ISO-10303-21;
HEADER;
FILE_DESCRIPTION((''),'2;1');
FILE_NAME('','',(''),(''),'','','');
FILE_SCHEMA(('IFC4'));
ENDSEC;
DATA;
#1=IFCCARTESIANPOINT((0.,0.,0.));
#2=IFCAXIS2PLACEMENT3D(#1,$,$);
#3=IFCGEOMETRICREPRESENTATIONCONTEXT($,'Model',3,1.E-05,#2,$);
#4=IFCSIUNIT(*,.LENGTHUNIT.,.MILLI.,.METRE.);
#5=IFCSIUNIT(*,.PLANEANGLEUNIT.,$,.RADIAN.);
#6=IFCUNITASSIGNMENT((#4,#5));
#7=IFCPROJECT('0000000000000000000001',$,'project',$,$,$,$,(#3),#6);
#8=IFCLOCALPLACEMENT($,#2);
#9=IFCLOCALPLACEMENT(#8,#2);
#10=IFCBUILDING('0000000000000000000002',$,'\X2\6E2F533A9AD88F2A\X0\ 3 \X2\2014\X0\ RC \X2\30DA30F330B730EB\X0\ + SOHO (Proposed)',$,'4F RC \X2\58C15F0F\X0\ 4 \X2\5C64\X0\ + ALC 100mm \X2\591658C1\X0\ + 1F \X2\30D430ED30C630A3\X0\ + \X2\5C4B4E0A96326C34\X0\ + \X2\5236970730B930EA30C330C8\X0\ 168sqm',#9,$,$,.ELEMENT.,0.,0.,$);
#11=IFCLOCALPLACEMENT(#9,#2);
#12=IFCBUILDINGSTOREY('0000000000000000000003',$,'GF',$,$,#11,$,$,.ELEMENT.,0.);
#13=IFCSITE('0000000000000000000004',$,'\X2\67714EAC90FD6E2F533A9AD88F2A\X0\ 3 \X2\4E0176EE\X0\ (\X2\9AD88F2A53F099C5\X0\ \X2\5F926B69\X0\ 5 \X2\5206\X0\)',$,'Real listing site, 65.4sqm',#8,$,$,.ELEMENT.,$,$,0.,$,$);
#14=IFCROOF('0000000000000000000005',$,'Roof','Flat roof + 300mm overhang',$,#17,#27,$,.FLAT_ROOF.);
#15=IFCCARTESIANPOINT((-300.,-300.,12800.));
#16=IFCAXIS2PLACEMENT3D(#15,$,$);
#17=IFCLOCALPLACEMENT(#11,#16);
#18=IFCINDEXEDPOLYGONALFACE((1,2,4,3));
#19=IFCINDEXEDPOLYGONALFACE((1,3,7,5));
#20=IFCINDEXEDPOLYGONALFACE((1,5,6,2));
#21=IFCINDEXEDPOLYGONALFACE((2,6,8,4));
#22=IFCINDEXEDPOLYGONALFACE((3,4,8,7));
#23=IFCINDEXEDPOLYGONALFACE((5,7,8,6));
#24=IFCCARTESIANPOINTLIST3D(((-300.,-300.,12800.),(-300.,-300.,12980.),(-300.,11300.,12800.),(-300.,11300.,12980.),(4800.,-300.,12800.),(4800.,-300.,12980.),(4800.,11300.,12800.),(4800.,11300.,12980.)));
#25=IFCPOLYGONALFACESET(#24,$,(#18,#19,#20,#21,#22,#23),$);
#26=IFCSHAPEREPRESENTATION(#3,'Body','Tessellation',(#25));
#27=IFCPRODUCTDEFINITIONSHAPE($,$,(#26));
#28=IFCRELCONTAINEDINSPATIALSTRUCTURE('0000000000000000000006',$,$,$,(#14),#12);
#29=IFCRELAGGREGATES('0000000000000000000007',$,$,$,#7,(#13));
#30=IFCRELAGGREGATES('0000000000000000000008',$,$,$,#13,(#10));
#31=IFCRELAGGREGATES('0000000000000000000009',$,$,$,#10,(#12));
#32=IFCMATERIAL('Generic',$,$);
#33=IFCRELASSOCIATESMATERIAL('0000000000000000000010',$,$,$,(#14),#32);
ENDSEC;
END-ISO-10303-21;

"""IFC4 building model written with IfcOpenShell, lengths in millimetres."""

from ifc_helpers import new_model, si_unit, frame, frame_2d, origin, place, context, project, spatial, rectangle, extrude, material, element, save


model = new_model("IFC4")

# Units and contexts
model_context = context("Model", 3, precision=1e-05, world=origin())
ifc_project = project(units=[si_unit("LENGTHUNIT", "METRE", prefix="MILLI"), si_unit("PLANEANGLEUNIT", "RADIAN")], contexts=[model_context])

# Site, building, storey
site_placement = place(None, origin())
site = spatial("IfcSite", under=ifc_project, at=site_placement, Name="東京都港区高輪 3 丁目 (高輪台駅 徒歩 5 分)", ObjectType="Real listing site, 65.4sqm", CompositionType="ELEMENT", RefElevation=0.0)
building_placement = place(site_placement, origin())
building = spatial("IfcBuilding", under=site, at=building_placement, Name="港区高輪 3 — RC ペンシル + SOHO (Proposed)", ObjectType="4F RC 壁式 4 層 + ALC 100mm 外壁 + 1F ピロティ + 屋上防水 + 制震スリット 168sqm", CompositionType="ELEMENT", ElevationOfRefHeight=0.0, ElevationOfTerrain=0.0)
storey_placement = place(building_placement, origin())
storey = spatial("IfcBuildingStorey", under=building, at=storey_placement, Name="GF", CompositionType="ELEMENT", Elevation=0.0)

# Shared definitions
ifc_material_1 = material(Name="Generic")

# Roof
roof_placement = place(storey_placement, frame((-300.0, -300.0, 12800.0)))
element("IfcRoof", 1, at=roof_placement, inside=storey, material=ifc_material_1, Name="Roof", Description="Flat roof + 300mm overhang", PredefinedType="FLAT_ROOF", context=model_context, shape_type="SweptSolid", body=[
    extrude(rectangle(XDim=5100.0, YDim=11600.0, at=frame_2d((2550.0, 5800.0))), frame((-300.0, -300.0, 12800.0)), (0.0, 0.0, 1.0), 180.0),
])

save(model, "model.ifc")
